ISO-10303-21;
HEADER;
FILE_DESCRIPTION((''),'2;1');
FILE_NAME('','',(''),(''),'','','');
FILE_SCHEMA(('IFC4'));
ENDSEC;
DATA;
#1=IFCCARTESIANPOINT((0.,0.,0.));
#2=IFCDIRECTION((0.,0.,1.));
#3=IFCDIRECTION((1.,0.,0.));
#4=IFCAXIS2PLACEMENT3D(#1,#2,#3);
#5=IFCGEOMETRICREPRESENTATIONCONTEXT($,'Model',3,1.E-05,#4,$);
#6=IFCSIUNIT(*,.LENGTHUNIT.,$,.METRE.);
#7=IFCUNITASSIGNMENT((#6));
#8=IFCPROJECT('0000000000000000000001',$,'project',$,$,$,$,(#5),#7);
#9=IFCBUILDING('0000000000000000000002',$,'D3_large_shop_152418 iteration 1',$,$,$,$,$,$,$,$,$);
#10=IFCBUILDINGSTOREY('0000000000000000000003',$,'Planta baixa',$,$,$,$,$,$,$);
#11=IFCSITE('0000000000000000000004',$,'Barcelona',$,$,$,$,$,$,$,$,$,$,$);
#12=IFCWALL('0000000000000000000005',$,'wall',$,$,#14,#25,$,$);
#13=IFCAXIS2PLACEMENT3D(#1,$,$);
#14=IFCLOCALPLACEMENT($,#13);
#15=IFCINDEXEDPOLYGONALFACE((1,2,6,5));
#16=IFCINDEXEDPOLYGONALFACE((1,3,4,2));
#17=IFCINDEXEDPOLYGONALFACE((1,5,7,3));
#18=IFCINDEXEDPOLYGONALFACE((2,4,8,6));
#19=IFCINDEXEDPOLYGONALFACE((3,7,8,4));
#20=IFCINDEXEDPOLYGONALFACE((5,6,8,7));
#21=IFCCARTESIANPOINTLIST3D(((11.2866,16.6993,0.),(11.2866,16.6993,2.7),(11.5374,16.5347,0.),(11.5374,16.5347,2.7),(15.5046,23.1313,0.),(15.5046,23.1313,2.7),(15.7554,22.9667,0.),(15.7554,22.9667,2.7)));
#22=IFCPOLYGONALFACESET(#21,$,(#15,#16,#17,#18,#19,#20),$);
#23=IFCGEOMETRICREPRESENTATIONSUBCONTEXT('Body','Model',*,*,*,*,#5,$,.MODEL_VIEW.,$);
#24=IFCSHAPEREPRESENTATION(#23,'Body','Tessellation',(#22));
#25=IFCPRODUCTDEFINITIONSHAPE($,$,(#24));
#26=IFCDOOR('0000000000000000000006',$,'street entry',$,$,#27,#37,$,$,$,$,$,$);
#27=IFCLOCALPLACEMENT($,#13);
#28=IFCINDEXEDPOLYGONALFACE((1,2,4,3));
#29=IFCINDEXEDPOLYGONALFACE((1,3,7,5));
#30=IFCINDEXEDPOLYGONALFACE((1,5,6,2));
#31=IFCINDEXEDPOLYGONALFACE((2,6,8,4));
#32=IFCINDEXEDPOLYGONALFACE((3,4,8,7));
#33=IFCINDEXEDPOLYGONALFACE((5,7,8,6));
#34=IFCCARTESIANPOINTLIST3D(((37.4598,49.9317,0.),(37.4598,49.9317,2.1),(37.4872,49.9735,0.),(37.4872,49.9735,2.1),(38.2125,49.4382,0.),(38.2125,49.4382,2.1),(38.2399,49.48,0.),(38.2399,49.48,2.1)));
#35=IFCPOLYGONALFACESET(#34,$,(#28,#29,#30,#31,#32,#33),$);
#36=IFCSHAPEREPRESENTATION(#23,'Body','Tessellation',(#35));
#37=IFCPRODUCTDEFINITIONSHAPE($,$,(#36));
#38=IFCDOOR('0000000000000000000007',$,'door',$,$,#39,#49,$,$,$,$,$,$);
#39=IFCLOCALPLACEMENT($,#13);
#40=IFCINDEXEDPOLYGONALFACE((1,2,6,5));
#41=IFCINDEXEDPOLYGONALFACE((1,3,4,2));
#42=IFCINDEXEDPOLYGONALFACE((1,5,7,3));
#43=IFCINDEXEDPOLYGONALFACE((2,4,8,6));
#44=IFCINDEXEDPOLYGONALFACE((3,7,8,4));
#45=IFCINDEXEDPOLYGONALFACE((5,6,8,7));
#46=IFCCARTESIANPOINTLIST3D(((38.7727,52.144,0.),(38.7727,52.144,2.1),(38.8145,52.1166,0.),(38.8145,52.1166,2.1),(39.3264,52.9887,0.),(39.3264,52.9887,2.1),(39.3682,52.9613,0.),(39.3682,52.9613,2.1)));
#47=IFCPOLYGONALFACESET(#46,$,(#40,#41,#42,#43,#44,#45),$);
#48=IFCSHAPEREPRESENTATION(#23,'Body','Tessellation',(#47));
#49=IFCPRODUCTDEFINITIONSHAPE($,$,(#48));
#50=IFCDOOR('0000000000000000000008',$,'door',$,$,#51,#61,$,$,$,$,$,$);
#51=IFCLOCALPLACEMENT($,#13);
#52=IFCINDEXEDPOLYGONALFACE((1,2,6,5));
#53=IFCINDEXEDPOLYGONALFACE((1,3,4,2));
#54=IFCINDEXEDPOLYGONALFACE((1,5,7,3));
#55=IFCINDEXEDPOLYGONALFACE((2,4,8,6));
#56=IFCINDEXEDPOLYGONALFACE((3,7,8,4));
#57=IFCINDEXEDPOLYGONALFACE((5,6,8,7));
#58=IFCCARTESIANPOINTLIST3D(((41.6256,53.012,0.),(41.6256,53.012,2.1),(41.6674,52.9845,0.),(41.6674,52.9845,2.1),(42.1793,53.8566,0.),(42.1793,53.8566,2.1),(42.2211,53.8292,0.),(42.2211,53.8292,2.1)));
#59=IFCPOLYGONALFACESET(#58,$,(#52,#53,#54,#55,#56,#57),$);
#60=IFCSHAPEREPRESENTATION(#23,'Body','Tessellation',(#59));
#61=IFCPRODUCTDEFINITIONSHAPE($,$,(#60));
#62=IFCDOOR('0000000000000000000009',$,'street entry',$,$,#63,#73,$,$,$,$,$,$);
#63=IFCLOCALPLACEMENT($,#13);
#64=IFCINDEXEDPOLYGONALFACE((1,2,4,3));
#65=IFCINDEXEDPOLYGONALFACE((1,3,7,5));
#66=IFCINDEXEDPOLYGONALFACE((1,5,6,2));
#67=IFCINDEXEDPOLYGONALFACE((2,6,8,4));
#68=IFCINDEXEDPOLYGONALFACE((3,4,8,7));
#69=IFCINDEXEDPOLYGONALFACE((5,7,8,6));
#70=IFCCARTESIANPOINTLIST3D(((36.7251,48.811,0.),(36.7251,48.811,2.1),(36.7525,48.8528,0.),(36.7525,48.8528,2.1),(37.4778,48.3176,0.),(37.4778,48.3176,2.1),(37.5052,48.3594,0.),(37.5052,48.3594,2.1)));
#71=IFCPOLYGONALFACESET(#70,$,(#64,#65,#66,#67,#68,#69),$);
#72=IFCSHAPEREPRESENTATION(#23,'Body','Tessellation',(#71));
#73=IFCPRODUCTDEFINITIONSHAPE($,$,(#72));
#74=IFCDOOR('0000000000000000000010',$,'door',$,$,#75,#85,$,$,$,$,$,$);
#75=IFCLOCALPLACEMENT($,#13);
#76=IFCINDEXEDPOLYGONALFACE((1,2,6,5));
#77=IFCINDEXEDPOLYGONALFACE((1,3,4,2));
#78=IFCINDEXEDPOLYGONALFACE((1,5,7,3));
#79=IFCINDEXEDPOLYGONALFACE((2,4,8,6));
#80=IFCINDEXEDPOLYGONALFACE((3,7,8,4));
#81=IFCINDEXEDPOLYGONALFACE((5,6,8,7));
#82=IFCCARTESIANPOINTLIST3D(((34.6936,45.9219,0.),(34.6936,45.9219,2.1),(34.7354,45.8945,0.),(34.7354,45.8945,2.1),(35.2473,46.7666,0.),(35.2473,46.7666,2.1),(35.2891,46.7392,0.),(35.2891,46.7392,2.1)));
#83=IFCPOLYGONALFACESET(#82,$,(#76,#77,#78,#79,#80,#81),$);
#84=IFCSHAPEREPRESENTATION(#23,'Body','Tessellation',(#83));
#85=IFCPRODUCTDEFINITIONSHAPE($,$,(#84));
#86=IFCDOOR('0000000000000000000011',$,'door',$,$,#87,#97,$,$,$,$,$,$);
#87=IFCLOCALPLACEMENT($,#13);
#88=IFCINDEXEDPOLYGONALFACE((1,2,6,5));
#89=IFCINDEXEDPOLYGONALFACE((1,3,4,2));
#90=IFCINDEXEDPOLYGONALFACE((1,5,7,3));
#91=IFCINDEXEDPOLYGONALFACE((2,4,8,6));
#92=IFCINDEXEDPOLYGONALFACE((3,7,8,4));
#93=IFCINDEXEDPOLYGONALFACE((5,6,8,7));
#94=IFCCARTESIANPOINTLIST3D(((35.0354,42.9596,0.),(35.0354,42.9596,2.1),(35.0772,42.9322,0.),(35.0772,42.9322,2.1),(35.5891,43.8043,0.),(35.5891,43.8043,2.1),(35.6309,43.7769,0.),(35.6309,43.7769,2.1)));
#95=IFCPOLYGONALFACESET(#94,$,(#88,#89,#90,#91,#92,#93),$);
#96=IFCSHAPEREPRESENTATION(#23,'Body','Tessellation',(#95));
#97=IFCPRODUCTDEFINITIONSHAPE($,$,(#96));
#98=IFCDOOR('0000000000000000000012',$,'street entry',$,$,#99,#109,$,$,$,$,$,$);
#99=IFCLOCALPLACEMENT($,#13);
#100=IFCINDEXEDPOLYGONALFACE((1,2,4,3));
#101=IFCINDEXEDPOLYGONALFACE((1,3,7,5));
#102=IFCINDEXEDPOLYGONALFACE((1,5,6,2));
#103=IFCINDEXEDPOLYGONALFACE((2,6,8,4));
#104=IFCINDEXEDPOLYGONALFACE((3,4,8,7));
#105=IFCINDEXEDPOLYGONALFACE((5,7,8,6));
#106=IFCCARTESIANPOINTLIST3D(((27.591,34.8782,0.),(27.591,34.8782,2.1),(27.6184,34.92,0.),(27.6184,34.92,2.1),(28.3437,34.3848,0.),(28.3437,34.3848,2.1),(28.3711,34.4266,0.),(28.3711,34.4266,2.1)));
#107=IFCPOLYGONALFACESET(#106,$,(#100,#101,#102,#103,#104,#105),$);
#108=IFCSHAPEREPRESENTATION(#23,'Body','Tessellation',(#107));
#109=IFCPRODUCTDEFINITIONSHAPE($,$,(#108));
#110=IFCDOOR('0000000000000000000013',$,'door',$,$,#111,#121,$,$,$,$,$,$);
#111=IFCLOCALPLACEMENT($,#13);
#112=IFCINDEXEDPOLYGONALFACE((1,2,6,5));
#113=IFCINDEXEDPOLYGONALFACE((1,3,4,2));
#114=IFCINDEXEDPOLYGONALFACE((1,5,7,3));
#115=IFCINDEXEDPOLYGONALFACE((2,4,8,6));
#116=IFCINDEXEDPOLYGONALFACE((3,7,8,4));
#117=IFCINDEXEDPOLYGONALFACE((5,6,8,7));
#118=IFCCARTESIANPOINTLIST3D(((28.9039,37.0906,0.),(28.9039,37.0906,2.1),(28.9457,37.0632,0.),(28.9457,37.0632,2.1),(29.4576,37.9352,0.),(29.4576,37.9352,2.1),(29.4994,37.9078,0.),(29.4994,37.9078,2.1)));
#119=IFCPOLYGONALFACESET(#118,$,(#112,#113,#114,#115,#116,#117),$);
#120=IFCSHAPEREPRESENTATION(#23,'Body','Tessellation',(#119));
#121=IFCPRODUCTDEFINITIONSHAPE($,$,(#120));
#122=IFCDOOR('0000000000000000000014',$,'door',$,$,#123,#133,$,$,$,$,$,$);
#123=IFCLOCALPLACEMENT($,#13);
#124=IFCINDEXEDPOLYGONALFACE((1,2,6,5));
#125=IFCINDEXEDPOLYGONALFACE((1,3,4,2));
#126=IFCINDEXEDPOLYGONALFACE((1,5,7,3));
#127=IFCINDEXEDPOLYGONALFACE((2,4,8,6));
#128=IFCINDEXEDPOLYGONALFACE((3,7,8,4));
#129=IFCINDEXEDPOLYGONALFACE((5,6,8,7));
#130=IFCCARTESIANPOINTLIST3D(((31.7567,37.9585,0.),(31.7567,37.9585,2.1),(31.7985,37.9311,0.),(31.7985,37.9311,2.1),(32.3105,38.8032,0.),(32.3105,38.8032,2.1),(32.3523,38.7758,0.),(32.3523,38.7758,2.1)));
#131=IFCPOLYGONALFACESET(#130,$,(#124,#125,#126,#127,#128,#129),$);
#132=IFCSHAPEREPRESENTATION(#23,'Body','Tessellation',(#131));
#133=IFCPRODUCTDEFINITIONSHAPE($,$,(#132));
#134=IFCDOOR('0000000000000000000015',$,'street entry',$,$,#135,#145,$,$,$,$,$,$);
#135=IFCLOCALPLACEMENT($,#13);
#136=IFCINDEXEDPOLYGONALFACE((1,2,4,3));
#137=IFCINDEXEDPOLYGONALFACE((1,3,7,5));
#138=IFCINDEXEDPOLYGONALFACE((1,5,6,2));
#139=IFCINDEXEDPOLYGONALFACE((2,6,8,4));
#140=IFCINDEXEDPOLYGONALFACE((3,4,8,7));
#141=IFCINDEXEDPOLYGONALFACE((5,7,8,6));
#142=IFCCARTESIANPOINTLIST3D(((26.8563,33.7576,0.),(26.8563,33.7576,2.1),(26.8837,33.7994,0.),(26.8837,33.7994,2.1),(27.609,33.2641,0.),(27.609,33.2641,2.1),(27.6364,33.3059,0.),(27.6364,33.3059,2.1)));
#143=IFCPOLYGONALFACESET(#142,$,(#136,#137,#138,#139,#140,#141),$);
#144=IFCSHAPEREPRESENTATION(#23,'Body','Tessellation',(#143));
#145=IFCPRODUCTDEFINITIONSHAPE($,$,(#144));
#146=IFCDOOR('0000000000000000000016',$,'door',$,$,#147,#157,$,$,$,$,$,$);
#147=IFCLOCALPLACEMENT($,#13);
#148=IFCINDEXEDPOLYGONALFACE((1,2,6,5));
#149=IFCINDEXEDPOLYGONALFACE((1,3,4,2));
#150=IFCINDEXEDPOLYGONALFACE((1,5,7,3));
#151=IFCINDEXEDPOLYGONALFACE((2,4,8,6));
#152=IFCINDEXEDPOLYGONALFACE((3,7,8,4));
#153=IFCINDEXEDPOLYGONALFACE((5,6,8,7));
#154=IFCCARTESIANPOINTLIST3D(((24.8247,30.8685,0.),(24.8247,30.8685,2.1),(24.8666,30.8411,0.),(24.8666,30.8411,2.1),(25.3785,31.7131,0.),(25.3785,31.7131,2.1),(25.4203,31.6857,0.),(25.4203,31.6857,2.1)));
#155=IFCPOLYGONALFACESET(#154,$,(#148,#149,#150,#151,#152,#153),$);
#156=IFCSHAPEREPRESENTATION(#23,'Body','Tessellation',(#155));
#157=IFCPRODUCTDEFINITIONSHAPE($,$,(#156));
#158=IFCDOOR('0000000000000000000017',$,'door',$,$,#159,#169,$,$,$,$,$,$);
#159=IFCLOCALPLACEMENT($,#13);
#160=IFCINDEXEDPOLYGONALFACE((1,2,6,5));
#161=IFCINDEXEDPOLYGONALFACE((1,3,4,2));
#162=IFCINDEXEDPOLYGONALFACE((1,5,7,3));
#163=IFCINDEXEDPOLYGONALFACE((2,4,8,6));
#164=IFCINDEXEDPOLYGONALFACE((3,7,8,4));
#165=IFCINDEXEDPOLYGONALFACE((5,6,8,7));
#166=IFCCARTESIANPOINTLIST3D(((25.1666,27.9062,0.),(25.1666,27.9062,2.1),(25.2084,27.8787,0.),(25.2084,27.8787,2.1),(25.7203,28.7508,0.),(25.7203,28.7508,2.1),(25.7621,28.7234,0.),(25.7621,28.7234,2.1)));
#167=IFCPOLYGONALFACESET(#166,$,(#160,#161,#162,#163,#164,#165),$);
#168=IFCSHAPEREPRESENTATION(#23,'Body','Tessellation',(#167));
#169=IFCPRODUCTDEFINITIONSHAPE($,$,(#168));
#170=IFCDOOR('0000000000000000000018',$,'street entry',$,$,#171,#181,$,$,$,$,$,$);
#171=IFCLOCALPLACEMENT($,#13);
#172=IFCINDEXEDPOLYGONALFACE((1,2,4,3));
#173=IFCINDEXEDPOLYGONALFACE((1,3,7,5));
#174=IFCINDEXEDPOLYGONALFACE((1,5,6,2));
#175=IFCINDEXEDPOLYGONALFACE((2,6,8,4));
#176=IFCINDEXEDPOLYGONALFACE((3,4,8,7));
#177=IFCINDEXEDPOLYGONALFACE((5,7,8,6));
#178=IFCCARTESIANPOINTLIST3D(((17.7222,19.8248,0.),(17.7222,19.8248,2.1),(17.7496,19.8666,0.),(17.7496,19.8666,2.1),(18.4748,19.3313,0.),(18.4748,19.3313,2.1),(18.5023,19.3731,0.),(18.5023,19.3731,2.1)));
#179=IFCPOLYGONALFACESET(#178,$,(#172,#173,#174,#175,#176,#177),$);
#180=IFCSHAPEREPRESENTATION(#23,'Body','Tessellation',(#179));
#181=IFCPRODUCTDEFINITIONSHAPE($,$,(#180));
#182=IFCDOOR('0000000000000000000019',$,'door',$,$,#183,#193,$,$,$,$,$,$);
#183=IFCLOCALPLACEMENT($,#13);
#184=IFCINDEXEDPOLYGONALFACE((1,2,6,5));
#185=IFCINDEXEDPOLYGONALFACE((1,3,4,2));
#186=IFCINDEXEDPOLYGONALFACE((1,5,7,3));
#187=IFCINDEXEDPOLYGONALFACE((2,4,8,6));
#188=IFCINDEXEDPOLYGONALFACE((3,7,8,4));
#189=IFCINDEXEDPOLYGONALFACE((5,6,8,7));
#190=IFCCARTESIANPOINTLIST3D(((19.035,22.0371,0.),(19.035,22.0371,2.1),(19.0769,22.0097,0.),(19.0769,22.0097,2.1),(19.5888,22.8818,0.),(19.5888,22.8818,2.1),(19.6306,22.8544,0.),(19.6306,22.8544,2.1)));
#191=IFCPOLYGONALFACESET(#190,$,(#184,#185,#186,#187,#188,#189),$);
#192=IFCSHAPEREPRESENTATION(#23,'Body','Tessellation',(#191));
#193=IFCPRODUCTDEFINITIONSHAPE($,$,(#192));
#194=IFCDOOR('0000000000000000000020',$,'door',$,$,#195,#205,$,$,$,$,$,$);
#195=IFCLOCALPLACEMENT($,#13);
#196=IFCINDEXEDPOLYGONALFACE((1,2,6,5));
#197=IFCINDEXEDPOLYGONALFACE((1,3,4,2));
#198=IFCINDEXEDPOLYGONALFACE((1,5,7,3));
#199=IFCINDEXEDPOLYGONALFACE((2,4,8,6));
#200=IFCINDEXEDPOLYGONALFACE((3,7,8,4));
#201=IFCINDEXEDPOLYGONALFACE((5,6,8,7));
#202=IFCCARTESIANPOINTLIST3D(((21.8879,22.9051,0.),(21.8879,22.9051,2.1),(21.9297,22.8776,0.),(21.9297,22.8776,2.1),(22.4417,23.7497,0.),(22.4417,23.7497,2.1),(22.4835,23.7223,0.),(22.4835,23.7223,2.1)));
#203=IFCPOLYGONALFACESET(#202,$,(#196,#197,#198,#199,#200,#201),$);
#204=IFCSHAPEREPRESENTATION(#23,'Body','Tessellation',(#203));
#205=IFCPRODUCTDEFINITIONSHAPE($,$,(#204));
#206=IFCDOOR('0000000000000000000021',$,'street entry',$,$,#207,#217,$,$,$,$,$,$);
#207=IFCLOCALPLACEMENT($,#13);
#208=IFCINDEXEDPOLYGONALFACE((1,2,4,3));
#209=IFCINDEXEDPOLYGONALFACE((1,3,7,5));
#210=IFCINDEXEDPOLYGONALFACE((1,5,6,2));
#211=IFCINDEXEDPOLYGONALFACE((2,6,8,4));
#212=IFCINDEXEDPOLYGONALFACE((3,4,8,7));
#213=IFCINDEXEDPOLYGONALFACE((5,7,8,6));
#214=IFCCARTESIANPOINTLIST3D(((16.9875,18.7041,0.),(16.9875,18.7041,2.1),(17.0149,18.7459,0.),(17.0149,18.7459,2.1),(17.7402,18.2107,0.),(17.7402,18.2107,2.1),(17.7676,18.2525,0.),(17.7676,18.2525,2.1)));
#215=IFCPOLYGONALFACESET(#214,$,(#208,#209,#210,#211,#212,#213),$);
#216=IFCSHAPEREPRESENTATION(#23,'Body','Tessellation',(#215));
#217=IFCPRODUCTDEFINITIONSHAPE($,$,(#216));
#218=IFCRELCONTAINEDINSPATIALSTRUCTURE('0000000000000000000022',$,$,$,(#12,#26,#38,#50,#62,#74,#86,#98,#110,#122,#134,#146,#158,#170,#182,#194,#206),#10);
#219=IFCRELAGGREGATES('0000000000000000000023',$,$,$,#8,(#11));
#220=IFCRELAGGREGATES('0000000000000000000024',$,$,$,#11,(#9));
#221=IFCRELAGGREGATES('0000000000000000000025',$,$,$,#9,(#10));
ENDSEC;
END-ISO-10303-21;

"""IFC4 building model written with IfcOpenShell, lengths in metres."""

from ifc_helpers import new_model, si_unit, origin, origin_with_axes, place, context, subcontext, project, spatial, polyline, outline, extrude, element, save


model = new_model("IFC4")

# Units and contexts
model_context = context("Model", 3, precision=1e-05, world=origin_with_axes())
body_context = subcontext(model_context, "Body", "Model", "MODEL_VIEW")
ifc_project = project(units=[si_unit("LENGTHUNIT", "METRE")], contexts=[model_context])

# Site, building, storey
site = spatial("IfcSite", under=ifc_project, Name="Barcelona")
building = spatial("IfcBuilding", under=site, Name="D3_large_shop_152418 iteration 1")
storey = spatial("IfcBuildingStorey", under=building, Name="Planta baixa")

# Wall
wall_1_placement = place(None, origin_with_axes())
element("IfcWall", 1, at=wall_1_placement, inside=storey, Name="wall", context=body_context, shape_type="SweptSolid", body=[
    extrude(outline(polyline([(11.2866, 16.6993), (15.5046, 23.1313), (15.7554, 22.9667), (11.5374, 16.5347), (11.2866, 16.6993)])), origin(), (0.0, 0.0, 1.0), 2.7),
])

# Doors
door_1_placement = place(None, origin_with_axes())
element("IfcDoor", 2, at=door_1_placement, inside=storey, Name="street entry", context=body_context, shape_type="SweptSolid", body=[
    extrude(outline(polyline([(37.4872, 49.9735), (38.2399, 49.48), (38.2125, 49.4382), (37.4598, 49.9317), (37.4872, 49.9735)])), origin(), (0.0, 0.0, 1.0), 2.1),
])
door_2_placement = place(None, origin_with_axes())
element("IfcDoor", 3, at=door_2_placement, inside=storey, Name="door", context=body_context, shape_type="SweptSolid", body=[
    extrude(outline(polyline([(39.3682, 52.9613), (38.8145, 52.1166), (38.7727, 52.144), (39.3264, 52.9887), (39.3682, 52.9613)])), origin(), (0.0, 0.0, 1.0), 2.1),
])
door_3_placement = place(None, origin_with_axes())
element("IfcDoor", 4, at=door_3_placement, inside=storey, Name="door", context=body_context, shape_type="SweptSolid", body=[
    extrude(outline(polyline([(41.6256, 53.012), (42.1793, 53.8566), (42.2211, 53.8292), (41.6674, 52.9845), (41.6256, 53.012)])), origin(), (0.0, 0.0, 1.0), 2.1),
])
door_4_placement = place(None, origin_with_axes())
element("IfcDoor", 5, at=door_4_placement, inside=storey, Name="street entry", context=body_context, shape_type="SweptSolid", body=[
    extrude(outline(polyline([(37.4778, 48.3176), (36.7251, 48.811), (36.7525, 48.8528), (37.5052, 48.3594), (37.4778, 48.3176)])), origin(), (0.0, 0.0, 1.0), 2.1),
])
door_5_placement = place(None, origin_with_axes())
element("IfcDoor", 6, at=door_5_placement, inside=storey, Name="door", context=body_context, shape_type="SweptSolid", body=[
    extrude(outline(polyline([(34.6936, 45.9219), (35.2473, 46.7666), (35.2891, 46.7392), (34.7354, 45.8945), (34.6936, 45.9219)])), origin(), (0.0, 0.0, 1.0), 2.1),
])
door_6_placement = place(None, origin_with_axes())
element("IfcDoor", 7, at=door_6_placement, inside=storey, Name="door", context=body_context, shape_type="SweptSolid", body=[
    extrude(outline(polyline([(35.0354, 42.9596), (35.5891, 43.8043), (35.6309, 43.7769), (35.0772, 42.9322), (35.0354, 42.9596)])), origin(), (0.0, 0.0, 1.0), 2.1),
])
door_7_placement = place(None, origin_with_axes())
element("IfcDoor", 8, at=door_7_placement, inside=storey, Name="street entry", context=body_context, shape_type="SweptSolid", body=[
    extrude(outline(polyline([(27.6184, 34.92), (28.3711, 34.4266), (28.3437, 34.3848), (27.591, 34.8782), (27.6184, 34.92)])), origin(), (0.0, 0.0, 1.0), 2.1),
])
door_8_placement = place(None, origin_with_axes())
element("IfcDoor", 9, at=door_8_placement, inside=storey, Name="door", context=body_context, shape_type="SweptSolid", body=[
    extrude(outline(polyline([(29.4994, 37.9078), (28.9457, 37.0632), (28.9039, 37.0906), (29.4576, 37.9352), (29.4994, 37.9078)])), origin(), (0.0, 0.0, 1.0), 2.1),
])
door_9_placement = place(None, origin_with_axes())
element("IfcDoor", 10, at=door_9_placement, inside=storey, Name="door", context=body_context, shape_type="SweptSolid", body=[
    extrude(outline(polyline([(32.3523, 38.7758), (31.7985, 37.9311), (31.7567, 37.9585), (32.3105, 38.8032), (32.3523, 38.7758)])), origin(), (0.0, 0.0, 1.0), 2.1),
])
door_10_placement = place(None, origin_with_axes())
element("IfcDoor", 11, at=door_10_placement, inside=storey, Name="street entry", context=body_context, shape_type="SweptSolid", body=[
    extrude(outline(polyline([(27.609, 33.2641), (26.8563, 33.7576), (26.8837, 33.7994), (27.6364, 33.3059), (27.609, 33.2641)])), origin(), (0.0, 0.0, 1.0), 2.1),
])
door_11_placement = place(None, origin_with_axes())
element("IfcDoor", 12, at=door_11_placement, inside=storey, Name="door", context=body_context, shape_type="SweptSolid", body=[
    extrude(outline(polyline([(25.4203, 31.6857), (24.8666, 30.8411), (24.8247, 30.8685), (25.3785, 31.7131), (25.4203, 31.6857)])), origin(), (0.0, 0.0, 1.0), 2.1),
])
door_12_placement = place(None, origin_with_axes())
element("IfcDoor", 13, at=door_12_placement, inside=storey, Name="door", context=body_context, shape_type="SweptSolid", body=[
    extrude(outline(polyline([(25.7621, 28.7234), (25.2084, 27.8787), (25.1666, 27.9062), (25.7203, 28.7508), (25.7621, 28.7234)])), origin(), (0.0, 0.0, 1.0), 2.1),
])
door_13_placement = place(None, origin_with_axes())
element("IfcDoor", 14, at=door_13_placement, inside=storey, Name="street entry", context=body_context, shape_type="SweptSolid", body=[
    extrude(outline(polyline([(17.7496, 19.8666), (18.5023, 19.3731), (18.4748, 19.3313), (17.7222, 19.8248), (17.7496, 19.8666)])), origin(), (0.0, 0.0, 1.0), 2.1),
])
door_14_placement = place(None, origin_with_axes())
element("IfcDoor", 15, at=door_14_placement, inside=storey, Name="door", context=body_context, shape_type="SweptSolid", body=[
    extrude(outline(polyline([(19.035, 22.0371), (19.5888, 22.8818), (19.6306, 22.8544), (19.0769, 22.0097), (19.035, 22.0371)])), origin(), (0.0, 0.0, 1.0), 2.1),
])
door_15_placement = place(None, origin_with_axes())
element("IfcDoor", 16, at=door_15_placement, inside=storey, Name="door", context=body_context, shape_type="SweptSolid", body=[
    extrude(outline(polyline([(21.8879, 22.9051), (22.4417, 23.7497), (22.4835, 23.7223), (21.9297, 22.8776), (21.8879, 22.9051)])), origin(), (0.0, 0.0, 1.0), 2.1),
])
door_16_placement = place(None, origin_with_axes())
element("IfcDoor", 17, at=door_16_placement, inside=storey, Name="street entry", context=body_context, shape_type="SweptSolid", body=[
    extrude(outline(polyline([(17.7402, 18.2107), (16.9875, 18.7041), (17.0149, 18.7459), (17.7676, 18.2525), (17.7402, 18.2107)])), origin(), (0.0, 0.0, 1.0), 2.1),
])

save(model, "model.ifc")
